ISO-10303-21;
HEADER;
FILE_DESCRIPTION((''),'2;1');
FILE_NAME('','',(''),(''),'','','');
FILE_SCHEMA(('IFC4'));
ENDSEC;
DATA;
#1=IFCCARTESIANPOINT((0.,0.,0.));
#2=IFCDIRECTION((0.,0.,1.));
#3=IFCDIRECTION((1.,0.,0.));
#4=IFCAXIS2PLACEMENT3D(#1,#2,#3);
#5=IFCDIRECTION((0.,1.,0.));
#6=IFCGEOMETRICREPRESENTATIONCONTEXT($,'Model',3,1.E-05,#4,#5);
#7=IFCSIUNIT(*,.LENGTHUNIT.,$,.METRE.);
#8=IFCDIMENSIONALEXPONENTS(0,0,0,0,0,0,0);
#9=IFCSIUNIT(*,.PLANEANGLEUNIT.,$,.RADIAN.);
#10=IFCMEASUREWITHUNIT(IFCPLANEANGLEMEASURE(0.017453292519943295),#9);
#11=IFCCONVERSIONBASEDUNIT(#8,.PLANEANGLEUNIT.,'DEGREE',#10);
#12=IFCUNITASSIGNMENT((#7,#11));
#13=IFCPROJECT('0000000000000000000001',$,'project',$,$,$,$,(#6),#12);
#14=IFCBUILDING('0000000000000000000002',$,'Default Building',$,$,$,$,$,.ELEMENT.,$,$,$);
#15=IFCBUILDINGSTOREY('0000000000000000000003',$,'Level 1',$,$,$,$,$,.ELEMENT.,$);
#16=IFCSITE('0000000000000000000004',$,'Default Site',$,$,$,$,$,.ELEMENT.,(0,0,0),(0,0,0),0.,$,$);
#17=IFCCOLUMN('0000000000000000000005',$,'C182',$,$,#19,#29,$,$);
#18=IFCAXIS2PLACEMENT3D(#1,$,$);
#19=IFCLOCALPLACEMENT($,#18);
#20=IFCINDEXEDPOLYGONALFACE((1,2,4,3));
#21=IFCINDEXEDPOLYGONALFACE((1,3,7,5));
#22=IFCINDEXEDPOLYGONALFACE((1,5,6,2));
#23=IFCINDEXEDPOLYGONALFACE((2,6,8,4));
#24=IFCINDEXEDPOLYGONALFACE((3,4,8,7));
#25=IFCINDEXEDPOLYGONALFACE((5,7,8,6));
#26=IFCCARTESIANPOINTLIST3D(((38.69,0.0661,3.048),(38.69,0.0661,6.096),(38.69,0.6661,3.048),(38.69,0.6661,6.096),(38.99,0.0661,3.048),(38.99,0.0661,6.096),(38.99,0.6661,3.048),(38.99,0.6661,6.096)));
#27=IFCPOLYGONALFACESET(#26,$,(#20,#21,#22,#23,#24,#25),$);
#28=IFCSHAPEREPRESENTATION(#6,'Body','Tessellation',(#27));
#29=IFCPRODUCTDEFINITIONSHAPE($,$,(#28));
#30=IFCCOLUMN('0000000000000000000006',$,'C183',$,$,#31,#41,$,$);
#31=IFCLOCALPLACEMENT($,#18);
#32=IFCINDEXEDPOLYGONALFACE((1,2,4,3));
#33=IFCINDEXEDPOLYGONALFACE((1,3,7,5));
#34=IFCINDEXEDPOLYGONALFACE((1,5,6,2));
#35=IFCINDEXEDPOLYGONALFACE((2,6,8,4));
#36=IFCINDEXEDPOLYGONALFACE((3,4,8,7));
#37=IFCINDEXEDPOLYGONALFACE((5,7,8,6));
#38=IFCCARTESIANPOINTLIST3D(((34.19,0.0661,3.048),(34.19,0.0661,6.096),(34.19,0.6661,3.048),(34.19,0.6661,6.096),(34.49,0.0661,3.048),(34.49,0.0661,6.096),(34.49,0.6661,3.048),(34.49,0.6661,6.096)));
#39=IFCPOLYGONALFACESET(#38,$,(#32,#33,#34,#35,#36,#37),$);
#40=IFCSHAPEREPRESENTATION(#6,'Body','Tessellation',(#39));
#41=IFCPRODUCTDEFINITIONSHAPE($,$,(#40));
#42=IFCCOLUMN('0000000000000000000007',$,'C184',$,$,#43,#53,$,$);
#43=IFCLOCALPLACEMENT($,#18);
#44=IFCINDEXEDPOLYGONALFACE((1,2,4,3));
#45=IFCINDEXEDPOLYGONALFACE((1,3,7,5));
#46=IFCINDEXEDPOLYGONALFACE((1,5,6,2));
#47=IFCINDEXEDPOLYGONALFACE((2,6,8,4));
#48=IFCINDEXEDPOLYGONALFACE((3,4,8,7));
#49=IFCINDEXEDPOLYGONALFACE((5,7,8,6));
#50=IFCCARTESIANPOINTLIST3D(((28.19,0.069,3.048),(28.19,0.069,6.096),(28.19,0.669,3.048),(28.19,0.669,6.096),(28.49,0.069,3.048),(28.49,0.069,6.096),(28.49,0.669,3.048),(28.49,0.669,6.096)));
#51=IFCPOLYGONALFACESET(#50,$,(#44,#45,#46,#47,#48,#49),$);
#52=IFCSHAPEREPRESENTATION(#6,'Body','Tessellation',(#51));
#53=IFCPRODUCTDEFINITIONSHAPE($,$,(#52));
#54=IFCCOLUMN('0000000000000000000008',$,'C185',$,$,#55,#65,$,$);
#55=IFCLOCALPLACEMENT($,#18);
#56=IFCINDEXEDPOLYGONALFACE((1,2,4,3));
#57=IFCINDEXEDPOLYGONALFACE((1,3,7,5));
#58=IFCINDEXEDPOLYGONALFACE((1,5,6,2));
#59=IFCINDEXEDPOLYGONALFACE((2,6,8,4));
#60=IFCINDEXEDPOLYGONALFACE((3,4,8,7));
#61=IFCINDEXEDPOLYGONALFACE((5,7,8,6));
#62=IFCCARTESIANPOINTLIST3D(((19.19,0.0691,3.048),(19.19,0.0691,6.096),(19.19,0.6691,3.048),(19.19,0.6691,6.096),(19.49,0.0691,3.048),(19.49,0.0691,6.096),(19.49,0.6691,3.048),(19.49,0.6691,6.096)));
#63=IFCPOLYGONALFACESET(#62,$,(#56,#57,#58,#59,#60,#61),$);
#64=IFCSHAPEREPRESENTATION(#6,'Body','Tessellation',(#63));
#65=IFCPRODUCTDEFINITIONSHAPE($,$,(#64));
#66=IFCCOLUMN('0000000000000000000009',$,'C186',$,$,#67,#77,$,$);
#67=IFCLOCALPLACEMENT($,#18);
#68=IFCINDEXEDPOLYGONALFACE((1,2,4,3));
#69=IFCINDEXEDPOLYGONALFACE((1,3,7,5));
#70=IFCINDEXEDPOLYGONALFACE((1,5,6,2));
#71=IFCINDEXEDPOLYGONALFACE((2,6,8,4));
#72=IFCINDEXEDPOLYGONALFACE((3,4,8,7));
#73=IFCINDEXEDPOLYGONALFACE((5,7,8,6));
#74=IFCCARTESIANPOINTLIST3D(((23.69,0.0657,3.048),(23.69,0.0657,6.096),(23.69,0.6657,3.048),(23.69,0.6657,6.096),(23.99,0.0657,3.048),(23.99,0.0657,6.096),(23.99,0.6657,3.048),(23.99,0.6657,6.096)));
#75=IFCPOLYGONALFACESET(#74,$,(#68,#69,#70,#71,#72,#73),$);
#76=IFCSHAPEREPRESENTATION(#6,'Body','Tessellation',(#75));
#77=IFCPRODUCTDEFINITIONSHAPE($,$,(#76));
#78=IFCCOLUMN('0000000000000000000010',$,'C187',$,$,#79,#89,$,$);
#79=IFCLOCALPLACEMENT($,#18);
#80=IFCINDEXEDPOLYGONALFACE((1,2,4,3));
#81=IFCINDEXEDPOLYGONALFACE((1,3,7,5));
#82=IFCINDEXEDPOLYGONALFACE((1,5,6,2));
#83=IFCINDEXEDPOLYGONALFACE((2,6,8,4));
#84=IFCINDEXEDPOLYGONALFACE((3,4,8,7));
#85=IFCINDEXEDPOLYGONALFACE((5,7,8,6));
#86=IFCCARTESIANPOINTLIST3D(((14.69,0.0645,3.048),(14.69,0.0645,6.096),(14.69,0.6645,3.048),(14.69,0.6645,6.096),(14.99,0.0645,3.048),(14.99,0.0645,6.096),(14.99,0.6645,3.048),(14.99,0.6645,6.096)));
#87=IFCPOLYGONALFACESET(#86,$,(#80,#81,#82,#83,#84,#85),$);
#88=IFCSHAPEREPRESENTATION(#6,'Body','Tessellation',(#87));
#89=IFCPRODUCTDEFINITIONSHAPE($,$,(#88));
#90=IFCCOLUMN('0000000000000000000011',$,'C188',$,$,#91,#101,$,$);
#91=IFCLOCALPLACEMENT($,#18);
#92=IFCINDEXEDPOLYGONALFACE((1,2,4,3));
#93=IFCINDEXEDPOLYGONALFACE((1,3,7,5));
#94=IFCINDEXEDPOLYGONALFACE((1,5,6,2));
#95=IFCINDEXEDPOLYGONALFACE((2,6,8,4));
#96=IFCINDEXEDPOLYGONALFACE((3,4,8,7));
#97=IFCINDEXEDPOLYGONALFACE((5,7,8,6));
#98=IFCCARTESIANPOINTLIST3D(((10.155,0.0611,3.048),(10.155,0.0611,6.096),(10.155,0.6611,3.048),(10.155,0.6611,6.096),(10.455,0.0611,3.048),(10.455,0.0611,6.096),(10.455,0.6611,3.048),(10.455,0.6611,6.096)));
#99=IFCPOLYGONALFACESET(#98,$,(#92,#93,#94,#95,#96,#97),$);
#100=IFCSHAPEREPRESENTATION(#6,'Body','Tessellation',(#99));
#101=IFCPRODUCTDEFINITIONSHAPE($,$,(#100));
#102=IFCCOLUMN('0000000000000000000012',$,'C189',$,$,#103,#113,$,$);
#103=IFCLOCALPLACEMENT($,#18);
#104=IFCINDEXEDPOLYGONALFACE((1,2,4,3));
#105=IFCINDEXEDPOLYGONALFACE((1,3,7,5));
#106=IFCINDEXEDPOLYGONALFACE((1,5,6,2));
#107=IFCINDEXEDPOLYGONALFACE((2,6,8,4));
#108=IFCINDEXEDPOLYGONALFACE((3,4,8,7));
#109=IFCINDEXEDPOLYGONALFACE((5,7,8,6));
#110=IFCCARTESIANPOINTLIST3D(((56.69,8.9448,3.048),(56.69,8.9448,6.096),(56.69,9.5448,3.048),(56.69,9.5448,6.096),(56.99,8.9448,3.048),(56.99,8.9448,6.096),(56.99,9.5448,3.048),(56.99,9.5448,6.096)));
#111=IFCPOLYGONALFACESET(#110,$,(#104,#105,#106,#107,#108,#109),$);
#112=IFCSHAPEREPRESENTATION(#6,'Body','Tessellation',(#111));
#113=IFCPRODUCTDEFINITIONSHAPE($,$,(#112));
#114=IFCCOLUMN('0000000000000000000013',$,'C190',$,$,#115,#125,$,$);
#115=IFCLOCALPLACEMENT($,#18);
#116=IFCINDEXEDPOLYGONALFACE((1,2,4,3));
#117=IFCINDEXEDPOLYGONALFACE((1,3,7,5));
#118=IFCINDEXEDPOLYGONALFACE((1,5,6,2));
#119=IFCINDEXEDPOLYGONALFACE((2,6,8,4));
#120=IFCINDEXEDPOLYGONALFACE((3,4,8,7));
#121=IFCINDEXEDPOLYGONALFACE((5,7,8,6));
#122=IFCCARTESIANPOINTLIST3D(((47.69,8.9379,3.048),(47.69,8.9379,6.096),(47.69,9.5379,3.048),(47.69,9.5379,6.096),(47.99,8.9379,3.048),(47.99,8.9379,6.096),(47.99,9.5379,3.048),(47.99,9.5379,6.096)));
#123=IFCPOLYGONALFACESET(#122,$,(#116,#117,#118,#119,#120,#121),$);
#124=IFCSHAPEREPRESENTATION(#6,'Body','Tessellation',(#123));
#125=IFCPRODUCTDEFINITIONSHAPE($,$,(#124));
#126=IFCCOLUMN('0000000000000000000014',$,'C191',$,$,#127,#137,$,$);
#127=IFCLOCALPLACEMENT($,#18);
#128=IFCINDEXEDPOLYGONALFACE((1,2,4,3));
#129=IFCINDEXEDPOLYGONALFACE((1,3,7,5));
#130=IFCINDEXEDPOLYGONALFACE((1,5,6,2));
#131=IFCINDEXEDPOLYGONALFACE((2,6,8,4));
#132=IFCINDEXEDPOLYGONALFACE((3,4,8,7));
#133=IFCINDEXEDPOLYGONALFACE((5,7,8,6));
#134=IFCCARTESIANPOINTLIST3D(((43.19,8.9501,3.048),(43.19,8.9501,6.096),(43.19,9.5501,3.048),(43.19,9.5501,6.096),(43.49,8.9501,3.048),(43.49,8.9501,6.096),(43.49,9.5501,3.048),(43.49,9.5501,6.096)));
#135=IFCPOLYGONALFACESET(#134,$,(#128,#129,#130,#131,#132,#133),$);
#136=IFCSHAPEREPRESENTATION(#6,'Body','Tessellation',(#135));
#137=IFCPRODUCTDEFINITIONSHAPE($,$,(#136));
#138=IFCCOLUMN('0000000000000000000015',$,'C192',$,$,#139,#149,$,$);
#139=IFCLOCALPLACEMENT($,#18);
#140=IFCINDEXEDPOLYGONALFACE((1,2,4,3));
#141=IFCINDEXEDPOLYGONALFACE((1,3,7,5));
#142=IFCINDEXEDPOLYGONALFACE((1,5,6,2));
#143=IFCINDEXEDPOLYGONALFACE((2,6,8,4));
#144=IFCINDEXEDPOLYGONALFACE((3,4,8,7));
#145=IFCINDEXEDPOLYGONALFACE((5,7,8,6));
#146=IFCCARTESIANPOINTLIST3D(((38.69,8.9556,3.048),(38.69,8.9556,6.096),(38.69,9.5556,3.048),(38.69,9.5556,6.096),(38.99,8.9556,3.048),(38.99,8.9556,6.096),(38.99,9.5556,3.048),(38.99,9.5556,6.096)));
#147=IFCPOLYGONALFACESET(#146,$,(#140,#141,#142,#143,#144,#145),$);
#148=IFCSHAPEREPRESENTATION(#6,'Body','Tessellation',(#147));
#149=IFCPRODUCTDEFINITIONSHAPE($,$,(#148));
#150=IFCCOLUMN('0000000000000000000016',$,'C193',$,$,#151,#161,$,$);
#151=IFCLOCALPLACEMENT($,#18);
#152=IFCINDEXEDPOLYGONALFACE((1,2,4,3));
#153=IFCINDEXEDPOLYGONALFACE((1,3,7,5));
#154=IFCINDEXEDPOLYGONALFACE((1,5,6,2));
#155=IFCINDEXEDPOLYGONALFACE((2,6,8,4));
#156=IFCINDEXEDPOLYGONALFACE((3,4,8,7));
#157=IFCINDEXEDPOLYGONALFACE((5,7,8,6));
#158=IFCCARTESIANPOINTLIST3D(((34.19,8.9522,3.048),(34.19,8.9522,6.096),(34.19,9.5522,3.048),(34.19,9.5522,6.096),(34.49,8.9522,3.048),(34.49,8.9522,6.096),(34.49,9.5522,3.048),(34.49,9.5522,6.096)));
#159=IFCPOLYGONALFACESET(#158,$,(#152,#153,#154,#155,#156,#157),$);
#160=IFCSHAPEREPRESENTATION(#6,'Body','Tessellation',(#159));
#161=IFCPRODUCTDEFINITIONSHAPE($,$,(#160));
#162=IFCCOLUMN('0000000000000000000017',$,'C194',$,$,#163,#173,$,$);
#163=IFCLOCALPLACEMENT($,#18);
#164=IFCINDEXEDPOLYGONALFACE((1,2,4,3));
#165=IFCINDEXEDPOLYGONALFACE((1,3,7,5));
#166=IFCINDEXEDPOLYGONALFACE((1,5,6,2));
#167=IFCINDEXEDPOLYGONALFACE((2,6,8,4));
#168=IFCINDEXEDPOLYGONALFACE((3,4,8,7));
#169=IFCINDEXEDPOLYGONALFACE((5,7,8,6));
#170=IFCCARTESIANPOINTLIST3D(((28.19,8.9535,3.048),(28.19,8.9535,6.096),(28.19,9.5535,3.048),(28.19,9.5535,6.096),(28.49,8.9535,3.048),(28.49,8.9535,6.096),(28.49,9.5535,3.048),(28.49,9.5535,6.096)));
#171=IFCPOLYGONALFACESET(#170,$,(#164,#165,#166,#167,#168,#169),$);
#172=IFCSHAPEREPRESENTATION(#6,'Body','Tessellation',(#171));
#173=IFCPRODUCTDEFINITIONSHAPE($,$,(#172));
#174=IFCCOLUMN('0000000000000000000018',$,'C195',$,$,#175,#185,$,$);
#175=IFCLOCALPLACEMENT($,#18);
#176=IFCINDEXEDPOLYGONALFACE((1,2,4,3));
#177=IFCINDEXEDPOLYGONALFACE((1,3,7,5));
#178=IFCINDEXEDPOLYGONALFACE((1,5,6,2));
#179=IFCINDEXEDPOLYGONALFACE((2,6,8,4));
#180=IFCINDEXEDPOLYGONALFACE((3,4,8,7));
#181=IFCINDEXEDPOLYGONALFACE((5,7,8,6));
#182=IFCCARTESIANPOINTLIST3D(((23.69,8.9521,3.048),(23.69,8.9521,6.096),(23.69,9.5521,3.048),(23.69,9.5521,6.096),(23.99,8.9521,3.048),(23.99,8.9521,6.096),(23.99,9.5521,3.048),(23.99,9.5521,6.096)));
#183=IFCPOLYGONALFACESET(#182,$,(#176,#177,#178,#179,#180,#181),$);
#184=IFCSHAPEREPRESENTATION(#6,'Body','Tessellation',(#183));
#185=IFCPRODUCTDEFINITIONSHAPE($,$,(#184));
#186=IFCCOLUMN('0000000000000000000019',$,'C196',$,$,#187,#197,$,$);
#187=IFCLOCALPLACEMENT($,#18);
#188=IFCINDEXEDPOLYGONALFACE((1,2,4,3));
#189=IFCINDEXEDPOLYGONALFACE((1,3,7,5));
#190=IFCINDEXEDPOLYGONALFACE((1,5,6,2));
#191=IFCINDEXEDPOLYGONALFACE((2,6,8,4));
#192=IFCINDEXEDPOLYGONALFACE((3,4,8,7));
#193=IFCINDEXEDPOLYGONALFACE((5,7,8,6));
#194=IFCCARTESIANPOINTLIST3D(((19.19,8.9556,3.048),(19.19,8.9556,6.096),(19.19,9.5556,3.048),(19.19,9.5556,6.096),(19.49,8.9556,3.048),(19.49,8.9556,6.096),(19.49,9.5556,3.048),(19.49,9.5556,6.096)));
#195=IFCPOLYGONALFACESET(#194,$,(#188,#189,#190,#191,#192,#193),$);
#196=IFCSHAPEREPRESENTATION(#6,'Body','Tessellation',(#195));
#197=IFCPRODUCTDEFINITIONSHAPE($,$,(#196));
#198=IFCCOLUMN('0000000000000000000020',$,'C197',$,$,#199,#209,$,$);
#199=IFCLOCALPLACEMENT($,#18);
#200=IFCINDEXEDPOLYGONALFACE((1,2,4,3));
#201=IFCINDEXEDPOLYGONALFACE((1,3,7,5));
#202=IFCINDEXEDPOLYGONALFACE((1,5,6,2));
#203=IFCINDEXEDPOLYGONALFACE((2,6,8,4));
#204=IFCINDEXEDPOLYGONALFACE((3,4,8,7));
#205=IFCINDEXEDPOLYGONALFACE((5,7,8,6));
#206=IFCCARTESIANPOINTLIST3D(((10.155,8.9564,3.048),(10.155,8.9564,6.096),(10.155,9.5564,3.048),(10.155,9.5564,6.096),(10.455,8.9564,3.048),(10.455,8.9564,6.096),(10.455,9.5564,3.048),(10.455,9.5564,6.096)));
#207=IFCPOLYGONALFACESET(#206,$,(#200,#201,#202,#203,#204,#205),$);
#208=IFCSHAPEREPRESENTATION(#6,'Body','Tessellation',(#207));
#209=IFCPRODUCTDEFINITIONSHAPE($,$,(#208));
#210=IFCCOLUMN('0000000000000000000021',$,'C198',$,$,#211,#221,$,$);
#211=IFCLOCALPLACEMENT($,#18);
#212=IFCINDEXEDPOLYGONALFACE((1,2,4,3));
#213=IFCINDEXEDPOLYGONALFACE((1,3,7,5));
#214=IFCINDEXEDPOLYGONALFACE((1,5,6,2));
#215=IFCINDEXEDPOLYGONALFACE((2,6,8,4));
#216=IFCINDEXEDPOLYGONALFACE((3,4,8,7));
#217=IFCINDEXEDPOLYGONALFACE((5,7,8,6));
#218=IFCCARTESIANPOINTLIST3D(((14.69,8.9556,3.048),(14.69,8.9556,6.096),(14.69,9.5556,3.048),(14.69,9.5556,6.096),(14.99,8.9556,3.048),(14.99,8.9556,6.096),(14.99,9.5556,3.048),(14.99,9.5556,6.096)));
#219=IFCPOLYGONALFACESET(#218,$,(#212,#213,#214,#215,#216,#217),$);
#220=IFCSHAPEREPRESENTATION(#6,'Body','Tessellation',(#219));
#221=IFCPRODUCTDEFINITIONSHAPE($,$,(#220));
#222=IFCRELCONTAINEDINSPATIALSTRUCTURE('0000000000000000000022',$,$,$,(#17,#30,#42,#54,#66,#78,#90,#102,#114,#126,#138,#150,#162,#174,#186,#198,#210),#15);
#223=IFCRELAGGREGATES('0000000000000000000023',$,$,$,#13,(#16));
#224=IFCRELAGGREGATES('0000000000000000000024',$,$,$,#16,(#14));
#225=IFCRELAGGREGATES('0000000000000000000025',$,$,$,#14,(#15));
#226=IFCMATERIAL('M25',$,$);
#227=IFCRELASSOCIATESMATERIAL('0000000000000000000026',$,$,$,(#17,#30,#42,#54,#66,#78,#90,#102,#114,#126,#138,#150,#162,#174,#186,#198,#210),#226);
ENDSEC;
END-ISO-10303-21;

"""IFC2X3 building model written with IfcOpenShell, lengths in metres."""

from ifc_helpers import new_model, entity, si_unit, converted_unit, direction, frame, frame_2d, origin_with_axes, place, context, project, spatial, rectangle, extrude, material, element, save


model = new_model("IFC2X3")

# Units and contexts
model_context = context("Model", 3, precision=1e-05, world=origin_with_axes(), true_north=direction((0.0, 1.0, 0.0)))
ifc_project = project(units=[si_unit("LENGTHUNIT", "METRE"), converted_unit("PLANEANGLEUNIT", "DEGREE", entity("IfcPlaneAngleMeasure", 0.017453292519943295), si_unit("PLANEANGLEUNIT", "RADIAN"), dimensions=[0, 0, 0, 0, 0, 0, 0])], contexts=[model_context])

# Site, building, storey
site = spatial("IfcSite", under=ifc_project, Name="Default Site", CompositionType="ELEMENT", RefLatitude=(0, 0, 0), RefLongitude=(0, 0, 0), RefElevation=0.0)
building = spatial("IfcBuilding", under=site, Name="Default Building", CompositionType="ELEMENT")
storey = spatial("IfcBuildingStorey", under=building, Name="Level 1", CompositionType="ELEMENT")

# Columns
ifc_material = material(Name="M25")
placement = place(None, origin_with_axes())
element("IfcColumn", 1, at=placement, inside=storey, material=ifc_material, Name="C182", context=model_context, shape_type="SweptSolid", body=[
    extrude(rectangle(XDim=0.3, YDim=0.6, at=frame_2d((0.0, 0.0), x_axis=(1.0, 0.0, 0.0))), frame((38.84, 0.3661, 3.048), z_axis=(0.0, 0.0, 1.0), x_axis=(1.0, 0.0, 0.0)), (0.0, 0.0, 1.0), 3.048),
])
element("IfcColumn", 2, at=placement, inside=storey, material=ifc_material, Name="C183", context=model_context, shape_type="SweptSolid", body=[
    extrude(rectangle(XDim=0.3, YDim=0.6, at=frame_2d((0.0, 0.0), x_axis=(1.0, 0.0, 0.0))), frame((34.34, 0.3661, 3.048), z_axis=(0.0, 0.0, 1.0), x_axis=(1.0, 0.0, 0.0)), (0.0, 0.0, 1.0), 3.048),
])
element("IfcColumn", 3, at=placement, inside=storey, material=ifc_material, Name="C184", context=model_context, shape_type="SweptSolid", body=[
    extrude(rectangle(XDim=0.3, YDim=0.6, at=frame_2d((0.0, 0.0), x_axis=(1.0, 0.0, 0.0))), frame((28.34, 0.369, 3.048), z_axis=(0.0, 0.0, 1.0), x_axis=(1.0, 0.0, 0.0)), (0.0, 0.0, 1.0), 3.048),
])
element("IfcColumn", 4, at=placement, inside=storey, material=ifc_material, Name="C185", context=model_context, shape_type="SweptSolid", body=[
    extrude(rectangle(XDim=0.3, YDim=0.6, at=frame_2d((0.0, 0.0), x_axis=(1.0, 0.0, 0.0))), frame((19.34, 0.3691, 3.048), z_axis=(0.0, 0.0, 1.0), x_axis=(1.0, 0.0, 0.0)), (0.0, 0.0, 1.0), 3.048),
])
element("IfcColumn", 5, at=placement, inside=storey, material=ifc_material, Name="C186", context=model_context, shape_type="SweptSolid", body=[
    extrude(rectangle(XDim=0.3, YDim=0.6, at=frame_2d((0.0, 0.0), x_axis=(1.0, 0.0, 0.0))), frame((23.84, 0.3657, 3.048), z_axis=(0.0, 0.0, 1.0), x_axis=(1.0, 0.0, 0.0)), (0.0, 0.0, 1.0), 3.048),
])
element("IfcColumn", 6, at=placement, inside=storey, material=ifc_material, Name="C187", context=model_context, shape_type="SweptSolid", body=[
    extrude(rectangle(XDim=0.3, YDim=0.6, at=frame_2d((0.0, 0.0), x_axis=(1.0, 0.0, 0.0))), frame((14.84, 0.3645, 3.048), z_axis=(0.0, 0.0, 1.0), x_axis=(1.0, 0.0, 0.0)), (0.0, 0.0, 1.0), 3.048),
])
element("IfcColumn", 7, at=placement, inside=storey, material=ifc_material, Name="C188", context=model_context, shape_type="SweptSolid", body=[
    extrude(rectangle(XDim=0.3, YDim=0.6, at=frame_2d((0.0, 0.0), x_axis=(1.0, 0.0, 0.0))), frame((10.305, 0.3611, 3.048), z_axis=(0.0, 0.0, 1.0), x_axis=(1.0, 0.0, 0.0)), (0.0, 0.0, 1.0), 3.048),
])
element("IfcColumn", 8, at=placement, inside=storey, material=ifc_material, Name="C189", context=model_context, shape_type="SweptSolid", body=[
    extrude(rectangle(XDim=0.3, YDim=0.6, at=frame_2d((0.0, 0.0), x_axis=(1.0, 0.0, 0.0))), frame((56.84, 9.2448, 3.048), z_axis=(0.0, 0.0, 1.0), x_axis=(1.0, 0.0, 0.0)), (0.0, 0.0, 1.0), 3.048),
])
element("IfcColumn", 9, at=placement, inside=storey, material=ifc_material, Name="C190", context=model_context, shape_type="SweptSolid", body=[
    extrude(rectangle(XDim=0.3, YDim=0.6, at=frame_2d((0.0, 0.0), x_axis=(1.0, 0.0, 0.0))), frame((47.84, 9.2379, 3.048), z_axis=(0.0, 0.0, 1.0), x_axis=(1.0, 0.0, 0.0)), (0.0, 0.0, 1.0), 3.048),
])
element("IfcColumn", 10, at=placement, inside=storey, material=ifc_material, Name="C191", context=model_context, shape_type="SweptSolid", body=[
    extrude(rectangle(XDim=0.3, YDim=0.6, at=frame_2d((0.0, 0.0), x_axis=(1.0, 0.0, 0.0))), frame((43.34, 9.2501, 3.048), z_axis=(0.0, 0.0, 1.0), x_axis=(1.0, 0.0, 0.0)), (0.0, 0.0, 1.0), 3.048),
])
element("IfcColumn", 11, at=placement, inside=storey, material=ifc_material, Name="C192", context=model_context, shape_type="SweptSolid", body=[
    extrude(rectangle(XDim=0.3, YDim=0.6, at=frame_2d((0.0, 0.0), x_axis=(1.0, 0.0, 0.0))), frame((38.84, 9.2556, 3.048), z_axis=(0.0, 0.0, 1.0), x_axis=(1.0, 0.0, 0.0)), (0.0, 0.0, 1.0), 3.048),
])
element("IfcColumn", 12, at=placement, inside=storey, material=ifc_material, Name="C193", context=model_context, shape_type="SweptSolid", body=[
    extrude(rectangle(XDim=0.3, YDim=0.6, at=frame_2d((0.0, 0.0), x_axis=(1.0, 0.0, 0.0))), frame((34.34, 9.2522, 3.048), z_axis=(0.0, 0.0, 1.0), x_axis=(1.0, 0.0, 0.0)), (0.0, 0.0, 1.0), 3.048),
])
element("IfcColumn", 13, at=placement, inside=storey, material=ifc_material, Name="C194", context=model_context, shape_type="SweptSolid", body=[
    extrude(rectangle(XDim=0.3, YDim=0.6, at=frame_2d((0.0, 0.0), x_axis=(1.0, 0.0, 0.0))), frame((28.34, 9.2535, 3.048), z_axis=(0.0, 0.0, 1.0), x_axis=(1.0, 0.0, 0.0)), (0.0, 0.0, 1.0), 3.048),
])
element("IfcColumn", 14, at=placement, inside=storey, material=ifc_material, Name="C195", context=model_context, shape_type="SweptSolid", body=[
    extrude(rectangle(XDim=0.3, YDim=0.6, at=frame_2d((0.0, 0.0), x_axis=(1.0, 0.0, 0.0))), frame((23.84, 9.2521, 3.048), z_axis=(0.0, 0.0, 1.0), x_axis=(1.0, 0.0, 0.0)), (0.0, 0.0, 1.0), 3.048),
])
element("IfcColumn", 15, at=placement, inside=storey, material=ifc_material, Name="C196", context=model_context, shape_type="SweptSolid", body=[
    extrude(rectangle(XDim=0.3, YDim=0.6, at=frame_2d((0.0, 0.0), x_axis=(1.0, 0.0, 0.0))), frame((19.34, 9.2556, 3.048), z_axis=(0.0, 0.0, 1.0), x_axis=(1.0, 0.0, 0.0)), (0.0, 0.0, 1.0), 3.048),
])
element("IfcColumn", 16, at=placement, inside=storey, material=ifc_material, Name="C197", context=model_context, shape_type="SweptSolid", body=[
    extrude(rectangle(XDim=0.3, YDim=0.6, at=frame_2d((0.0, 0.0), x_axis=(1.0, 0.0, 0.0))), frame((10.305, 9.2564, 3.048), z_axis=(0.0, 0.0, 1.0), x_axis=(1.0, 0.0, 0.0)), (0.0, 0.0, 1.0), 3.048),
])
element("IfcColumn", 17, at=placement, inside=storey, material=ifc_material, Name="C198", context=model_context, shape_type="SweptSolid", body=[
    extrude(rectangle(XDim=0.3, YDim=0.6, at=frame_2d((0.0, 0.0), x_axis=(1.0, 0.0, 0.0))), frame((14.84, 9.2556, 3.048), z_axis=(0.0, 0.0, 1.0), x_axis=(1.0, 0.0, 0.0)), (0.0, 0.0, 1.0), 3.048),
])

save(model, "model.ifc")
